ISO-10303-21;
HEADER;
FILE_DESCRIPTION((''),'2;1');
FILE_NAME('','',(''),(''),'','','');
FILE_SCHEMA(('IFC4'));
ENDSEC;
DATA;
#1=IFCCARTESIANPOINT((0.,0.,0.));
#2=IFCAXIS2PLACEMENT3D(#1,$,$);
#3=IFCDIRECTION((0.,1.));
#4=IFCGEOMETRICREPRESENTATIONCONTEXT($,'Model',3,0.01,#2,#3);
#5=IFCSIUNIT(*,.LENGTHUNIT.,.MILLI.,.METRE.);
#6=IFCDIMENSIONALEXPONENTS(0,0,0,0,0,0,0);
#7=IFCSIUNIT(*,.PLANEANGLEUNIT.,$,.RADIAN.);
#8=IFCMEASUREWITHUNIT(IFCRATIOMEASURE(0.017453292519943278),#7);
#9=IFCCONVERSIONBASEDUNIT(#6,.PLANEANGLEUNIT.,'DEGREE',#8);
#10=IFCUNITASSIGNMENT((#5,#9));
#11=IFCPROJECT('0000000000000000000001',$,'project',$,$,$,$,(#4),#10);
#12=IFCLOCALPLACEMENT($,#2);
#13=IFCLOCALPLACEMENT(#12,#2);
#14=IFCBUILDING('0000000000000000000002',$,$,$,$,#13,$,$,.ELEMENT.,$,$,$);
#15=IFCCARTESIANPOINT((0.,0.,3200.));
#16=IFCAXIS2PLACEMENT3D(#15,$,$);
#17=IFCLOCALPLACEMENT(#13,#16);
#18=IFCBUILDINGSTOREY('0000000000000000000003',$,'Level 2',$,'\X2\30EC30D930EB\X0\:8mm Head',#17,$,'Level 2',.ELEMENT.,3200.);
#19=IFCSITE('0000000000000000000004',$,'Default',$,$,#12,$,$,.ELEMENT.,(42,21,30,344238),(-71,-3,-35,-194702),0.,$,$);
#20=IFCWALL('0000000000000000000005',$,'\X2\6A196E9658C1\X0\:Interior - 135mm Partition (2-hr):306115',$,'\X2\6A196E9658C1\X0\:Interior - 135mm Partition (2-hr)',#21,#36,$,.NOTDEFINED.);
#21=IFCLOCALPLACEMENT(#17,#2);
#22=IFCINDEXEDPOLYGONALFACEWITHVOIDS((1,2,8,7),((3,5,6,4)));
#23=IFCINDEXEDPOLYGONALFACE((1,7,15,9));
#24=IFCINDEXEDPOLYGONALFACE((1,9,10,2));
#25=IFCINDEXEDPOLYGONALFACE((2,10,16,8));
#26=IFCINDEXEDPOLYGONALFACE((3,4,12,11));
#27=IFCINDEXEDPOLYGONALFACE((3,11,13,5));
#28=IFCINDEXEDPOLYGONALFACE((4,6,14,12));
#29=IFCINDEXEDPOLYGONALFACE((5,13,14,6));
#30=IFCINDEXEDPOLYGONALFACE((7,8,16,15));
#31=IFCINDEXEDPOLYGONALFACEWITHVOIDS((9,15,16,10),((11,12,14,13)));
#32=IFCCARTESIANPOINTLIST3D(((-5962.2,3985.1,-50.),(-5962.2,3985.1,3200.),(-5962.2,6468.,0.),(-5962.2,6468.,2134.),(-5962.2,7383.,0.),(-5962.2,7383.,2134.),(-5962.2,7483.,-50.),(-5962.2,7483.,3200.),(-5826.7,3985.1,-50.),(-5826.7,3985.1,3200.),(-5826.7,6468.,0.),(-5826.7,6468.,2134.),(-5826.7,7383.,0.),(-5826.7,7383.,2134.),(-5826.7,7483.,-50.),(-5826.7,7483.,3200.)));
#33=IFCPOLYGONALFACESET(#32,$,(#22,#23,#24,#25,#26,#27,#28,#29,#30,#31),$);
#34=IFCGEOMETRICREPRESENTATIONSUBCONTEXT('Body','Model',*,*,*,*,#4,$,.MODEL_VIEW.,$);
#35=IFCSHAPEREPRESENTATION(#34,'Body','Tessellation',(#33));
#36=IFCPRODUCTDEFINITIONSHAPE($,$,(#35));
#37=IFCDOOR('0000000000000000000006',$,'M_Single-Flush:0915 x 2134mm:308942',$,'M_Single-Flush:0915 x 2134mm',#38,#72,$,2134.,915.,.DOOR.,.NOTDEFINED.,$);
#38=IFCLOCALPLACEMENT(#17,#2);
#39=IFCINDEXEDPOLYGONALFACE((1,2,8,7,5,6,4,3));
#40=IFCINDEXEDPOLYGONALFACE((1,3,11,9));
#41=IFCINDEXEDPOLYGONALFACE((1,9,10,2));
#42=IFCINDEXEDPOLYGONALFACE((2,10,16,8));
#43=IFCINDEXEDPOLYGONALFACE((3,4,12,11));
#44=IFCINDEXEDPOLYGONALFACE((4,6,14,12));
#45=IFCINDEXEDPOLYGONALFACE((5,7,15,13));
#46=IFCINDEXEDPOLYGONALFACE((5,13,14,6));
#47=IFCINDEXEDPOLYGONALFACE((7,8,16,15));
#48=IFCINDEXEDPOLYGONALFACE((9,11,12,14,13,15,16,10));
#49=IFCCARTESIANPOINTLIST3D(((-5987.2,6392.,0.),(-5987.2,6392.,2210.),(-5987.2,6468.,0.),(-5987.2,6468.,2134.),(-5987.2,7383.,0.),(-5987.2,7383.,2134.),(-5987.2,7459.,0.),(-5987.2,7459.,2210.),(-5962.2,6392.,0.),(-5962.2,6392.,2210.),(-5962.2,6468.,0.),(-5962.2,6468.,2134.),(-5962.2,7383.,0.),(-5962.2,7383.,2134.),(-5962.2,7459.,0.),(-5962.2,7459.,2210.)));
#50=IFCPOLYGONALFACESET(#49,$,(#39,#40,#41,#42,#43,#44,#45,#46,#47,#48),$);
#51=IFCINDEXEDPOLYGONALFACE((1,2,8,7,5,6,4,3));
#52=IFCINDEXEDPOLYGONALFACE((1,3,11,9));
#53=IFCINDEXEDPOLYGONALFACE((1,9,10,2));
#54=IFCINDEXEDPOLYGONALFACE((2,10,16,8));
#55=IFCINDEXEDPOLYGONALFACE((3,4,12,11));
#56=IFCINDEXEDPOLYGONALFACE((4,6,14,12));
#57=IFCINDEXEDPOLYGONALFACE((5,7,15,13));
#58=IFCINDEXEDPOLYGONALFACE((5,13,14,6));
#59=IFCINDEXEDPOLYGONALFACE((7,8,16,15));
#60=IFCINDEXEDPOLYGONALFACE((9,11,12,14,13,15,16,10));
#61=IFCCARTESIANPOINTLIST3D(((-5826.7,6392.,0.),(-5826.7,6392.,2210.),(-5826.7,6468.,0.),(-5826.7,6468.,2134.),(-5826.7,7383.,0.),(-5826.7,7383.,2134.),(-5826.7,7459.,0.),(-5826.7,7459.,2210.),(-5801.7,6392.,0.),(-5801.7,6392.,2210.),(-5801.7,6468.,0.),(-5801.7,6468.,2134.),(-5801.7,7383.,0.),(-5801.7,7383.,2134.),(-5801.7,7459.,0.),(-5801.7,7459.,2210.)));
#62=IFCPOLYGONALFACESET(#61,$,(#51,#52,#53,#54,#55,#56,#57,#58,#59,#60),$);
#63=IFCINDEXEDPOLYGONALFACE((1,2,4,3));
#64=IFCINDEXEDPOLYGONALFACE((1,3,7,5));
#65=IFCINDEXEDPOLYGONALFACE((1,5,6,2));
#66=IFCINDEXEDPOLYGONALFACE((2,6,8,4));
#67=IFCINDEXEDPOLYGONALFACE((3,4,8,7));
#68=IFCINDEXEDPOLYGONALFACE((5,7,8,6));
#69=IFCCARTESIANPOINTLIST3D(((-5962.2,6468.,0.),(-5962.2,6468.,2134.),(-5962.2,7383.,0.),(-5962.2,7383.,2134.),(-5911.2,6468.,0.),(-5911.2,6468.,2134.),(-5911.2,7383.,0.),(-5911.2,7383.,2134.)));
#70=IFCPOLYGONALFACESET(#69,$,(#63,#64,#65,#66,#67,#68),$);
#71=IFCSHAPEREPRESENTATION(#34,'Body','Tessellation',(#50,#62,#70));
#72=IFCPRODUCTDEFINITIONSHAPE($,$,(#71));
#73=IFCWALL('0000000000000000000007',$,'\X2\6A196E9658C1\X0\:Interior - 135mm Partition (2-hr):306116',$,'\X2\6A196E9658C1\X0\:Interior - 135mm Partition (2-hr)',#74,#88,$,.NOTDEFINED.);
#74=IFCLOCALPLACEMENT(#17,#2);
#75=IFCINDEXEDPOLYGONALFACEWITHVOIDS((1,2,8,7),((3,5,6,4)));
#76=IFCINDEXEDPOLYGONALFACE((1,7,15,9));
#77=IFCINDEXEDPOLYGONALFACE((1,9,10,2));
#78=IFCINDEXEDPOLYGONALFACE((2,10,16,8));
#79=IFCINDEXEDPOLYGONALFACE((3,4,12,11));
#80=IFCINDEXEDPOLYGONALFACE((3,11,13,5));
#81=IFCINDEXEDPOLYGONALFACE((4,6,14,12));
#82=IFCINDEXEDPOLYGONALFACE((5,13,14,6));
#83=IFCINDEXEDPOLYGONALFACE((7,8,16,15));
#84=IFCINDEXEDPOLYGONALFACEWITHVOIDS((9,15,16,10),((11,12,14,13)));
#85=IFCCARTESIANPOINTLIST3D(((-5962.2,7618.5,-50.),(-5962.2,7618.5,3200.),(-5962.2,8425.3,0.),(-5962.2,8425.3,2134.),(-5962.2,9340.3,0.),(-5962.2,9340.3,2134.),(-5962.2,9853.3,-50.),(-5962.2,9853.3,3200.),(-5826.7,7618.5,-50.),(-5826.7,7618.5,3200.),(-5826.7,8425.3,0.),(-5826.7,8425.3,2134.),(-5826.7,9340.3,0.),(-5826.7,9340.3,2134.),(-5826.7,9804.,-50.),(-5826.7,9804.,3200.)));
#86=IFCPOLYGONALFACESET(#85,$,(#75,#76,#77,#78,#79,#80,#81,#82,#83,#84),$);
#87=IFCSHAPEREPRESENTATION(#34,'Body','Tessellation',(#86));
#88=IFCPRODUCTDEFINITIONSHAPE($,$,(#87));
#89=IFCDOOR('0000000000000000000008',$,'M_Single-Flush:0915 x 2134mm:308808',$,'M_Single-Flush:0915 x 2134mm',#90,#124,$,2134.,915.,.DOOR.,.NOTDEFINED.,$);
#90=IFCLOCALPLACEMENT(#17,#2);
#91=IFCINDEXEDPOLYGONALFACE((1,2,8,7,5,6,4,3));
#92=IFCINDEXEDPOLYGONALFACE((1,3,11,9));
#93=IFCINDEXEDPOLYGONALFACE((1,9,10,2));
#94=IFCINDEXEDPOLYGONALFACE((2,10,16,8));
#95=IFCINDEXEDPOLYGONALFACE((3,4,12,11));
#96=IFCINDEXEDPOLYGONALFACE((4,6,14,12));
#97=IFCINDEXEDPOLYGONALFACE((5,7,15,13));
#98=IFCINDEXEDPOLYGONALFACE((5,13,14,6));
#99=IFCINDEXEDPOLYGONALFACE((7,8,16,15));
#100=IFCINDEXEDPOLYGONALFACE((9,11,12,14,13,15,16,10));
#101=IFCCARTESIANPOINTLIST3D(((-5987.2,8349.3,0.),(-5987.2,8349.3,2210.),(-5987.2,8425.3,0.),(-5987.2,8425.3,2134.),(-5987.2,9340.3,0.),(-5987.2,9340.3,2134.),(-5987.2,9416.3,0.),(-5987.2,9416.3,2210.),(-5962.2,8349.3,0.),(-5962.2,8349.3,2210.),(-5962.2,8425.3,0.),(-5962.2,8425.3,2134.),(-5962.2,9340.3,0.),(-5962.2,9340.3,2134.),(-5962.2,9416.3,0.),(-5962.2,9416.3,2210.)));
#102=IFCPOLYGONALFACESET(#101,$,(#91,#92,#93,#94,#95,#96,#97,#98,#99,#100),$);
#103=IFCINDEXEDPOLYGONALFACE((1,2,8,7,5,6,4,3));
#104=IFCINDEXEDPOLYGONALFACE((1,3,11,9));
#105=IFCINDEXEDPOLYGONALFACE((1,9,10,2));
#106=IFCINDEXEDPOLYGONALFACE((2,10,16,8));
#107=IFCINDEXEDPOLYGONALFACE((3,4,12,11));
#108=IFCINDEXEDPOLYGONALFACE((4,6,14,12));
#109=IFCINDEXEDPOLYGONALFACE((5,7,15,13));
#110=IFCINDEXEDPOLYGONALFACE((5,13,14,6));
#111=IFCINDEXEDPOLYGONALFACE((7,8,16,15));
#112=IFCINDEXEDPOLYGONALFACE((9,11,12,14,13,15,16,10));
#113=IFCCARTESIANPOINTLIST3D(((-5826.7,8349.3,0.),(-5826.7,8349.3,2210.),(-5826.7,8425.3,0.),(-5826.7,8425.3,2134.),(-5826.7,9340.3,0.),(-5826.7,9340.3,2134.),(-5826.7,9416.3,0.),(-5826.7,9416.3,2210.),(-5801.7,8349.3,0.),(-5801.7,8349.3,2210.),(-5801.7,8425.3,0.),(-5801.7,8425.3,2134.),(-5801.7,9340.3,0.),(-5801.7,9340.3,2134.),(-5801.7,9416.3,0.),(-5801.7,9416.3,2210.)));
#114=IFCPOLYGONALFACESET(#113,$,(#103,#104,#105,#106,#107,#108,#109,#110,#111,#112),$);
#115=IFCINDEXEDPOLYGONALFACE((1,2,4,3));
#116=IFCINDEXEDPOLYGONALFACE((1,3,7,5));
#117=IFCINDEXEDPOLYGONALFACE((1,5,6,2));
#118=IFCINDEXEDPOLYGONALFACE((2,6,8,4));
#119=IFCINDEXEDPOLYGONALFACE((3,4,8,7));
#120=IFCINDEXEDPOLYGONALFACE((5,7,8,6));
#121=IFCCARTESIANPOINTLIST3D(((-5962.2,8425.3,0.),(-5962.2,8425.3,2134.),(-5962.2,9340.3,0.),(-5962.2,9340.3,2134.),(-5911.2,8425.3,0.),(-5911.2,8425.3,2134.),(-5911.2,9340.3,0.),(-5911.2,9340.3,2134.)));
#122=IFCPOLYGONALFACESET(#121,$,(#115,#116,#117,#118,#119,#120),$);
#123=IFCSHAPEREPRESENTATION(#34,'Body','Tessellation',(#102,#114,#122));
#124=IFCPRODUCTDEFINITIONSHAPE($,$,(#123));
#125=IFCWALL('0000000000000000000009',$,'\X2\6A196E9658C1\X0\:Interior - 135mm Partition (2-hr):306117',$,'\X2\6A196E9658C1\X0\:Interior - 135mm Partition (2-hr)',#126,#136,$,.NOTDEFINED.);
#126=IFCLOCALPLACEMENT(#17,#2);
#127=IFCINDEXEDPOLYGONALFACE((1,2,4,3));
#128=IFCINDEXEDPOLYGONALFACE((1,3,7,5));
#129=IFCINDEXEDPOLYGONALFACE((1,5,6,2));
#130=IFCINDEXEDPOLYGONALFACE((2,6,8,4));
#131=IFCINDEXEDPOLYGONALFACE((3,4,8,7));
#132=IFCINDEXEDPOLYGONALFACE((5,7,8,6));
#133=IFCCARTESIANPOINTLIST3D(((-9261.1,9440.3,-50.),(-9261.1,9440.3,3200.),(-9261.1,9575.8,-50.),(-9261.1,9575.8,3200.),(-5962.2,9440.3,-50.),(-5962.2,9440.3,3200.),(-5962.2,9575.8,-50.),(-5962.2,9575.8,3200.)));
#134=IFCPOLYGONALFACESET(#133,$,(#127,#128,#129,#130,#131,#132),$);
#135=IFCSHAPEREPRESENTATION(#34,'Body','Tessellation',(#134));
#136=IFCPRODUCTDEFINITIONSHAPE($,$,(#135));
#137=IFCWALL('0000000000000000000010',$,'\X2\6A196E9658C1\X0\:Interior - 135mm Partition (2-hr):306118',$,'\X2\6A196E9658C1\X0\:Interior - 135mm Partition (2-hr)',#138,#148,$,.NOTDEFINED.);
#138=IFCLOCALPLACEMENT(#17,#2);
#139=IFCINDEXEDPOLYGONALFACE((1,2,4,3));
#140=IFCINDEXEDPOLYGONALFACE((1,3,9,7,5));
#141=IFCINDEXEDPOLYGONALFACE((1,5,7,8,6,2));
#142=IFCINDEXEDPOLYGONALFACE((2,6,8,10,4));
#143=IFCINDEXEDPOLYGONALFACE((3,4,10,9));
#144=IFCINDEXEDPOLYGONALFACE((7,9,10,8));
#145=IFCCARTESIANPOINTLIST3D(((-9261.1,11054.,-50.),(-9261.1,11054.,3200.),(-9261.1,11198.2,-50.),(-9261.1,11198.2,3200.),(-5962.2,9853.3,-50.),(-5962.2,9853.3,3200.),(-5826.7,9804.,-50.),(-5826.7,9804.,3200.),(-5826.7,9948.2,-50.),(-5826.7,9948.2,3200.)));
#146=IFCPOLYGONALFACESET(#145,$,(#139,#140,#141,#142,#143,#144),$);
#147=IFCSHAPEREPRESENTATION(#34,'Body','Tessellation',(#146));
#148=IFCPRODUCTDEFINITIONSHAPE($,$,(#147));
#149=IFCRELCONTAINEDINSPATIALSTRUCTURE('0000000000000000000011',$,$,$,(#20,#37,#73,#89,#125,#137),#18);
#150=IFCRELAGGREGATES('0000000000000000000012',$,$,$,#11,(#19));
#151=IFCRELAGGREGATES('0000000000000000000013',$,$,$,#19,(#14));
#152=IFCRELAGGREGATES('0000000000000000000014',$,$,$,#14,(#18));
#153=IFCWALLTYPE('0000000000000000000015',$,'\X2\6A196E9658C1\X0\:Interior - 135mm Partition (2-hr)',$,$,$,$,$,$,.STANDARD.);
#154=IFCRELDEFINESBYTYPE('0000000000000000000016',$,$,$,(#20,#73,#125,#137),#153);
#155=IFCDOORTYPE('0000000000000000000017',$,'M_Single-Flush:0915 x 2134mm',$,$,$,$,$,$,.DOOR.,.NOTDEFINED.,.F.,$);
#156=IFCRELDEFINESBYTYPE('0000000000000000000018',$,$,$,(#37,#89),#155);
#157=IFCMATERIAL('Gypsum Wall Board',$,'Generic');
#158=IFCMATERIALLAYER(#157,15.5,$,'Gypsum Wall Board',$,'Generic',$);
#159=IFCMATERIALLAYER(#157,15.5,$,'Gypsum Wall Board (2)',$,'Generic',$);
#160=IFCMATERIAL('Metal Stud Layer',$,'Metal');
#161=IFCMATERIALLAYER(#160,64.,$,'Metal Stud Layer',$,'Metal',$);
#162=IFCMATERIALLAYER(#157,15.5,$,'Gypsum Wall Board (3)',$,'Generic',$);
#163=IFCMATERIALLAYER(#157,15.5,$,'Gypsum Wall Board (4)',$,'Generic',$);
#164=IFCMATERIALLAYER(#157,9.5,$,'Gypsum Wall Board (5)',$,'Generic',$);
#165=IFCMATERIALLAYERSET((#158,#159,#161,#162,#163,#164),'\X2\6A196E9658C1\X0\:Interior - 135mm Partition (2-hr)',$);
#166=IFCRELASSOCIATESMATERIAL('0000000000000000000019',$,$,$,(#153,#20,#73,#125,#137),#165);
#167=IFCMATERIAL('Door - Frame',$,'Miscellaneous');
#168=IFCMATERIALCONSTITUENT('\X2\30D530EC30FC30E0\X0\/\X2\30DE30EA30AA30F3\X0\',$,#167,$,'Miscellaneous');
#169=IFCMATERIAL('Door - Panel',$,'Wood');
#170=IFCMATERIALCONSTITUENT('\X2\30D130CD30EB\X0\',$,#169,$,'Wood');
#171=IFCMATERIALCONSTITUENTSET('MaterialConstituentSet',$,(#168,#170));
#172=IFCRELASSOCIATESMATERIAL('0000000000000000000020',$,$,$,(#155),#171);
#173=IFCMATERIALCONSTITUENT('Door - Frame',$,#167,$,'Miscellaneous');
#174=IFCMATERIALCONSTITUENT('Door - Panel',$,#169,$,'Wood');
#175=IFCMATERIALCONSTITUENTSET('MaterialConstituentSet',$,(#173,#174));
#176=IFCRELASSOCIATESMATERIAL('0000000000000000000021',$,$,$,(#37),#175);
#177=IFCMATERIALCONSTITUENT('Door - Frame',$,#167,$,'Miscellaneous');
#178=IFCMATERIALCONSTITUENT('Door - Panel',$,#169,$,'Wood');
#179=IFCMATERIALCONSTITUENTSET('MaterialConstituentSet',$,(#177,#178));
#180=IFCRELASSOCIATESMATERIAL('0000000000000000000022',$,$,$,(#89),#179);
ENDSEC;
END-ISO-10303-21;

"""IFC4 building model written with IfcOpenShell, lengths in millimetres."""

from ifc_helpers import new_model, entity, si_unit, converted_unit, direction, frame, frame_2d, origin, place, context, subcontext, project, spatial, polyline, rectangle, outline, extrude, source, transform, mapped, material, layer, layer_set, layer_usage, constituent, constituent_set, type_object, type_shapes, element, fill, save


model = new_model("IFC4")

# Units and contexts
model_context = context("Model", 3, precision=0.01, world=origin(), true_north=direction((0.0, 1.0)))
body_context = subcontext(model_context, "Body", "Model", "MODEL_VIEW")
ifc_project = project(units=[si_unit("LENGTHUNIT", "METRE", prefix="MILLI"), converted_unit("PLANEANGLEUNIT", "DEGREE", entity("IfcRatioMeasure", 0.017453292519943278), si_unit("PLANEANGLEUNIT", "RADIAN"), dimensions=[0, 0, 0, 0, 0, 0, 0])], contexts=[model_context])

# Site, building, storey
site_placement = place(None, origin())
site = spatial("IfcSite", under=ifc_project, at=site_placement, Name="Default", CompositionType="ELEMENT", RefLatitude=(42, 21, 30, 344238), RefLongitude=(-71, -3, -35, -194702), RefElevation=0.0)
building_placement = place(site_placement, origin())
building = spatial("IfcBuilding", under=site, at=building_placement, CompositionType="ELEMENT")
storey_placement = place(building_placement, frame((0.0, 0.0, 3200.0)))
storey = spatial("IfcBuildingStorey", under=building, at=storey_placement, Name="Level 2", ObjectType="レベル:8mm Head", LongName="Level 2", CompositionType="ELEMENT", Elevation=3200.0)

# Shared definitions
ifc_material_1 = material(Name="Gypsum Wall Board", Category="Generic")
ifc_layer_1 = layer(ifc_material_1, 15.5, Name="Gypsum Wall Board", Category="Generic")
ifc_layer_2 = layer(ifc_material_1, 15.5, Name="Gypsum Wall Board (2)", Category="Generic")
ifc_material_2 = material(Name="Metal Stud Layer", Category="Metal")
ifc_layer_3 = layer(ifc_material_2, 64.0, Name="Metal Stud Layer", Category="Metal")
ifc_layer_4 = layer(ifc_material_1, 15.5, Name="Gypsum Wall Board (3)", Category="Generic")
ifc_layer_5 = layer(ifc_material_1, 15.5, Name="Gypsum Wall Board (4)", Category="Generic")
ifc_layer_6 = layer(ifc_material_1, 9.5, Name="Gypsum Wall Board (5)", Category="Generic")
ifc_layer_set_1 = layer_set([ifc_layer_1, ifc_layer_2, ifc_layer_3, ifc_layer_4, ifc_layer_5, ifc_layer_6], Name="標準壁:Interior - 135mm Partition (2-hr)")
wall_type = type_object("IfcWallType", Name="標準壁:Interior - 135mm Partition (2-hr)", PredefinedType="STANDARD", material=ifc_layer_set_1)
ifc_material_3 = material(Name="Door - Frame", Category="Miscellaneous")
ifc_material_4 = material(Name="Door - Panel", Category="Wood")
ifc_constituent_1 = constituent(ifc_material_3, Name="フレーム/マリオン", Category="Miscellaneous")
ifc_constituent_2 = constituent(ifc_material_4, Name="パネル", Category="Wood")
ifc_constituent_set_1 = constituent_set(constituents=[ifc_constituent_1, ifc_constituent_2], Name="MaterialConstituentSet")
door_type_1 = type_object("IfcDoorType", Name="M_Single-Flush:0915 x 2134mm", OperationType="NOTDEFINED", ParameterTakesPrecedence=False, PredefinedType="DOOR", material=ifc_constituent_set_1)
shared_shape_1 = source(origin(), body_context, "Body", "SweptSolid", [
    extrude(outline(polyline([(-533.5, -1124.0), (533.5, -1124.0), (533.5, 1086.0), (457.5, 1086.0), (457.5, -1048.0), (-457.5, -1048.0), (-457.5, 1086.0), (-533.5, 1086.0), (-533.5, -1124.0)])), frame((457.5, 135.5, 1086.0), z_axis=(0.0, 1.0, 0.0), x_axis=(1.0, 0.0, 0.0)), (0.0, 0.0, 1.0), 25.0),
    extrude(outline(polyline([(-1124.0, -533.5), (1086.0, -533.5), (1086.0, -457.5), (-1048.0, -457.5), (-1048.0, 457.5), (1086.0, 457.5), (1086.0, 533.5), (-1124.0, 533.5), (-1124.0, -533.5)])), frame((457.5, -25.0, 1086.0), z_axis=(0.0, 1.0, 0.0), x_axis=(0.0, 0.0, -1.0)), (0.0, 0.0, 1.0), 25.0),
    extrude(rectangle(XDim=51.0, YDim=915.0, at=frame_2d((0.0, 0.0), x_axis=(1.0, 0.0))), frame((457.5, 110.0, 0.0), z_axis=(0.0, 0.0, 1.0), x_axis=(0.0, 1.0, 0.0)), (0.0, 0.0, 1.0), 2134.0),
])
type_shapes(door_type_1, [shared_shape_1])

# Walls, openings, doors
ifc_layer_usage_1 = layer_usage(ifc_layer_set_1, "AXIS2", "NEGATIVE", 67.8)
wall_1_placement = place(storey_placement, frame((-5894.4, 7483.0, -50.0), z_axis=(0.0, 0.0, 1.0), x_axis=(0.0, -1.0, 0.0)))
wall_1 = element("IfcWall", 1, at=wall_1_placement, inside=storey, type_object=wall_type, material=ifc_layer_usage_1, Name="標準壁:Interior - 135mm Partition (2-hr):306115", ObjectType="標準壁:Interior - 135mm Partition (2-hr)", PredefinedType="NOTDEFINED", context=body_context, shape_type="SweptSolid", body=[
    extrude(rectangle(XDim=3497.9, YDim=135.5, at=frame_2d((1749.0, 0.0), x_axis=(-1.0, 0.0))), origin(), (0.0, 0.0, 1.0), 3250.0),
])
opening_1_placement = place(wall_1_placement, frame((1015.0, 67.7, 50.0)))
opening_1 = element("IfcOpeningElement", 2, at=opening_1_placement, cuts=wall_1, PredefinedType="OPENING", context=body_context, shape_type="SweptSolid", body=[
    extrude(rectangle(XDim=915.0, YDim=2134.0, at=frame_2d((1067.0, 457.5), x_axis=(0.0, 1.0))), frame((0.0, 0.0, 0.0), z_axis=(0.0, -1.0, 0.0), x_axis=(0.0, 0.0, 1.0)), (0.0, 0.0, 1.0), 135.5),
])
ifc_constituent_3 = constituent(ifc_material_3, Name="Door - Frame", Category="Miscellaneous")
ifc_constituent_4 = constituent(ifc_material_4, Name="Door - Panel", Category="Wood")
ifc_constituent_set_2 = constituent_set(constituents=[ifc_constituent_3, ifc_constituent_4], Name="MaterialConstituentSet")
door_1_placement = place(opening_1_placement, frame((0.0, 0.0, 0.0), z_axis=(0.0, 0.0, 1.0), x_axis=(-1.0, 0.0, 0.0)))
door_1 = element("IfcDoor", 3, at=door_1_placement, inside=storey, type_object=door_type_1, material=ifc_constituent_set_2, Name="M_Single-Flush:0915 x 2134mm:308942", ObjectType="M_Single-Flush:0915 x 2134mm", OperationType="NOTDEFINED", OverallHeight=2134.0, OverallWidth=915.0, PredefinedType="DOOR", context=body_context, shape_type="MappedRepresentation", body=[
    mapped(shared_shape_1, transform((0.0, 0.0, 0.0), scale=1.0)),
])
fill(opening_1, door_1)
ifc_layer_usage_2 = layer_usage(ifc_layer_set_1, "AXIS2", "NEGATIVE", 67.8)
wall_2_placement = place(storey_placement, frame((-5894.4, 7618.5, -50.0), z_axis=(0.0, 0.0, 1.0), x_axis=(0.0, 1.0, 0.0)))
wall_2 = element("IfcWall", 4, at=wall_2_placement, inside=storey, type_object=wall_type, material=ifc_layer_usage_2, Name="標準壁:Interior - 135mm Partition (2-hr):306116", ObjectType="標準壁:Interior - 135mm Partition (2-hr)", PredefinedType="NOTDEFINED", context=body_context, shape_type="SweptSolid", body=[
    extrude(outline(polyline([(2185.5, -67.8), (2234.8, 67.7), (1957.3, 67.8), (1821.8, 67.7), (0.0, 67.7), (0.0, -67.7), (2185.5, -67.8)])), origin(), (0.0, 0.0, 1.0), 3250.0),
])
opening_2_placement = place(wall_2_placement, frame((806.8, -67.8, 50.0)))
opening_2 = element("IfcOpeningElement", 5, at=opening_2_placement, cuts=wall_2, PredefinedType="OPENING", context=body_context, shape_type="SweptSolid", body=[
    extrude(rectangle(XDim=915.0, YDim=2134.0, at=frame_2d((1067.0, 457.5), x_axis=(0.0, 1.0))), frame((0.0, 0.0, 0.0), z_axis=(0.0, 1.0, 0.0), x_axis=(0.0, 0.0, 1.0)), (0.0, 0.0, 1.0), 135.5),
])
ifc_constituent_5 = constituent(ifc_material_3, Name="Door - Frame", Category="Miscellaneous")
ifc_constituent_6 = constituent(ifc_material_4, Name="Door - Panel", Category="Wood")
ifc_constituent_set_3 = constituent_set(constituents=[ifc_constituent_5, ifc_constituent_6], Name="MaterialConstituentSet")
door_2_placement = place(opening_2_placement, origin())
door_2 = element("IfcDoor", 6, at=door_2_placement, inside=storey, type_object=door_type_1, material=ifc_constituent_set_3, Name="M_Single-Flush:0915 x 2134mm:308808", ObjectType="M_Single-Flush:0915 x 2134mm", OperationType="NOTDEFINED", OverallHeight=2134.0, OverallWidth=915.0, PredefinedType="DOOR", context=body_context, shape_type="MappedRepresentation", body=[
    mapped(shared_shape_1, transform((0.0, 0.0, 0.0), scale=1.0)),
])
fill(opening_2, door_2)

# Walls
ifc_layer_usage_3 = layer_usage(ifc_layer_set_1, "AXIS2", "NEGATIVE", 67.8)
wall_3_placement = place(storey_placement, frame((-5962.2, 9508.0, -50.0), z_axis=(0.0, 0.0, 1.0), x_axis=(-1.0, 0.0, 0.0)))
element("IfcWall", 7, at=wall_3_placement, inside=storey, type_object=wall_type, material=ifc_layer_usage_3, Name="標準壁:Interior - 135mm Partition (2-hr):306117", ObjectType="標準壁:Interior - 135mm Partition (2-hr)", PredefinedType="NOTDEFINED", context=body_context, shape_type="SweptSolid", body=[
    extrude(rectangle(XDim=3298.9, YDim=135.5, at=frame_2d((1649.5, 0.0), x_axis=(-1.0, 0.0))), origin(), (0.0, 0.0, 1.0), 3250.0),
])
ifc_layer_usage_4 = layer_usage(ifc_layer_set_1, "AXIS2", "NEGATIVE", 67.8)
wall_4_placement = place(storey_placement, frame((-5803.5, 9867.7, -50.0), z_axis=(0.0, 0.0, 1.0), x_axis=(-0.939693, 0.34202, 0.0)))
element("IfcWall", 8, at=wall_4_placement, inside=storey, type_object=wall_type, material=ifc_layer_usage_4, Name="標準壁:Interior - 135mm Partition (2-hr):306118", ObjectType="標準壁:Interior - 135mm Partition (2-hr)", PredefinedType="NOTDEFINED", context=body_context, shape_type="SweptSolid", body=[
    extrude(outline(polyline([(3704.2, -67.8), (3654.8, 67.7), (144.2, 67.8), (0.0, 67.7), (49.3, -67.8), (3704.2, -67.8)])), origin(), (0.0, 0.0, 1.0), 3250.0),
])

save(model, "model.ifc")
